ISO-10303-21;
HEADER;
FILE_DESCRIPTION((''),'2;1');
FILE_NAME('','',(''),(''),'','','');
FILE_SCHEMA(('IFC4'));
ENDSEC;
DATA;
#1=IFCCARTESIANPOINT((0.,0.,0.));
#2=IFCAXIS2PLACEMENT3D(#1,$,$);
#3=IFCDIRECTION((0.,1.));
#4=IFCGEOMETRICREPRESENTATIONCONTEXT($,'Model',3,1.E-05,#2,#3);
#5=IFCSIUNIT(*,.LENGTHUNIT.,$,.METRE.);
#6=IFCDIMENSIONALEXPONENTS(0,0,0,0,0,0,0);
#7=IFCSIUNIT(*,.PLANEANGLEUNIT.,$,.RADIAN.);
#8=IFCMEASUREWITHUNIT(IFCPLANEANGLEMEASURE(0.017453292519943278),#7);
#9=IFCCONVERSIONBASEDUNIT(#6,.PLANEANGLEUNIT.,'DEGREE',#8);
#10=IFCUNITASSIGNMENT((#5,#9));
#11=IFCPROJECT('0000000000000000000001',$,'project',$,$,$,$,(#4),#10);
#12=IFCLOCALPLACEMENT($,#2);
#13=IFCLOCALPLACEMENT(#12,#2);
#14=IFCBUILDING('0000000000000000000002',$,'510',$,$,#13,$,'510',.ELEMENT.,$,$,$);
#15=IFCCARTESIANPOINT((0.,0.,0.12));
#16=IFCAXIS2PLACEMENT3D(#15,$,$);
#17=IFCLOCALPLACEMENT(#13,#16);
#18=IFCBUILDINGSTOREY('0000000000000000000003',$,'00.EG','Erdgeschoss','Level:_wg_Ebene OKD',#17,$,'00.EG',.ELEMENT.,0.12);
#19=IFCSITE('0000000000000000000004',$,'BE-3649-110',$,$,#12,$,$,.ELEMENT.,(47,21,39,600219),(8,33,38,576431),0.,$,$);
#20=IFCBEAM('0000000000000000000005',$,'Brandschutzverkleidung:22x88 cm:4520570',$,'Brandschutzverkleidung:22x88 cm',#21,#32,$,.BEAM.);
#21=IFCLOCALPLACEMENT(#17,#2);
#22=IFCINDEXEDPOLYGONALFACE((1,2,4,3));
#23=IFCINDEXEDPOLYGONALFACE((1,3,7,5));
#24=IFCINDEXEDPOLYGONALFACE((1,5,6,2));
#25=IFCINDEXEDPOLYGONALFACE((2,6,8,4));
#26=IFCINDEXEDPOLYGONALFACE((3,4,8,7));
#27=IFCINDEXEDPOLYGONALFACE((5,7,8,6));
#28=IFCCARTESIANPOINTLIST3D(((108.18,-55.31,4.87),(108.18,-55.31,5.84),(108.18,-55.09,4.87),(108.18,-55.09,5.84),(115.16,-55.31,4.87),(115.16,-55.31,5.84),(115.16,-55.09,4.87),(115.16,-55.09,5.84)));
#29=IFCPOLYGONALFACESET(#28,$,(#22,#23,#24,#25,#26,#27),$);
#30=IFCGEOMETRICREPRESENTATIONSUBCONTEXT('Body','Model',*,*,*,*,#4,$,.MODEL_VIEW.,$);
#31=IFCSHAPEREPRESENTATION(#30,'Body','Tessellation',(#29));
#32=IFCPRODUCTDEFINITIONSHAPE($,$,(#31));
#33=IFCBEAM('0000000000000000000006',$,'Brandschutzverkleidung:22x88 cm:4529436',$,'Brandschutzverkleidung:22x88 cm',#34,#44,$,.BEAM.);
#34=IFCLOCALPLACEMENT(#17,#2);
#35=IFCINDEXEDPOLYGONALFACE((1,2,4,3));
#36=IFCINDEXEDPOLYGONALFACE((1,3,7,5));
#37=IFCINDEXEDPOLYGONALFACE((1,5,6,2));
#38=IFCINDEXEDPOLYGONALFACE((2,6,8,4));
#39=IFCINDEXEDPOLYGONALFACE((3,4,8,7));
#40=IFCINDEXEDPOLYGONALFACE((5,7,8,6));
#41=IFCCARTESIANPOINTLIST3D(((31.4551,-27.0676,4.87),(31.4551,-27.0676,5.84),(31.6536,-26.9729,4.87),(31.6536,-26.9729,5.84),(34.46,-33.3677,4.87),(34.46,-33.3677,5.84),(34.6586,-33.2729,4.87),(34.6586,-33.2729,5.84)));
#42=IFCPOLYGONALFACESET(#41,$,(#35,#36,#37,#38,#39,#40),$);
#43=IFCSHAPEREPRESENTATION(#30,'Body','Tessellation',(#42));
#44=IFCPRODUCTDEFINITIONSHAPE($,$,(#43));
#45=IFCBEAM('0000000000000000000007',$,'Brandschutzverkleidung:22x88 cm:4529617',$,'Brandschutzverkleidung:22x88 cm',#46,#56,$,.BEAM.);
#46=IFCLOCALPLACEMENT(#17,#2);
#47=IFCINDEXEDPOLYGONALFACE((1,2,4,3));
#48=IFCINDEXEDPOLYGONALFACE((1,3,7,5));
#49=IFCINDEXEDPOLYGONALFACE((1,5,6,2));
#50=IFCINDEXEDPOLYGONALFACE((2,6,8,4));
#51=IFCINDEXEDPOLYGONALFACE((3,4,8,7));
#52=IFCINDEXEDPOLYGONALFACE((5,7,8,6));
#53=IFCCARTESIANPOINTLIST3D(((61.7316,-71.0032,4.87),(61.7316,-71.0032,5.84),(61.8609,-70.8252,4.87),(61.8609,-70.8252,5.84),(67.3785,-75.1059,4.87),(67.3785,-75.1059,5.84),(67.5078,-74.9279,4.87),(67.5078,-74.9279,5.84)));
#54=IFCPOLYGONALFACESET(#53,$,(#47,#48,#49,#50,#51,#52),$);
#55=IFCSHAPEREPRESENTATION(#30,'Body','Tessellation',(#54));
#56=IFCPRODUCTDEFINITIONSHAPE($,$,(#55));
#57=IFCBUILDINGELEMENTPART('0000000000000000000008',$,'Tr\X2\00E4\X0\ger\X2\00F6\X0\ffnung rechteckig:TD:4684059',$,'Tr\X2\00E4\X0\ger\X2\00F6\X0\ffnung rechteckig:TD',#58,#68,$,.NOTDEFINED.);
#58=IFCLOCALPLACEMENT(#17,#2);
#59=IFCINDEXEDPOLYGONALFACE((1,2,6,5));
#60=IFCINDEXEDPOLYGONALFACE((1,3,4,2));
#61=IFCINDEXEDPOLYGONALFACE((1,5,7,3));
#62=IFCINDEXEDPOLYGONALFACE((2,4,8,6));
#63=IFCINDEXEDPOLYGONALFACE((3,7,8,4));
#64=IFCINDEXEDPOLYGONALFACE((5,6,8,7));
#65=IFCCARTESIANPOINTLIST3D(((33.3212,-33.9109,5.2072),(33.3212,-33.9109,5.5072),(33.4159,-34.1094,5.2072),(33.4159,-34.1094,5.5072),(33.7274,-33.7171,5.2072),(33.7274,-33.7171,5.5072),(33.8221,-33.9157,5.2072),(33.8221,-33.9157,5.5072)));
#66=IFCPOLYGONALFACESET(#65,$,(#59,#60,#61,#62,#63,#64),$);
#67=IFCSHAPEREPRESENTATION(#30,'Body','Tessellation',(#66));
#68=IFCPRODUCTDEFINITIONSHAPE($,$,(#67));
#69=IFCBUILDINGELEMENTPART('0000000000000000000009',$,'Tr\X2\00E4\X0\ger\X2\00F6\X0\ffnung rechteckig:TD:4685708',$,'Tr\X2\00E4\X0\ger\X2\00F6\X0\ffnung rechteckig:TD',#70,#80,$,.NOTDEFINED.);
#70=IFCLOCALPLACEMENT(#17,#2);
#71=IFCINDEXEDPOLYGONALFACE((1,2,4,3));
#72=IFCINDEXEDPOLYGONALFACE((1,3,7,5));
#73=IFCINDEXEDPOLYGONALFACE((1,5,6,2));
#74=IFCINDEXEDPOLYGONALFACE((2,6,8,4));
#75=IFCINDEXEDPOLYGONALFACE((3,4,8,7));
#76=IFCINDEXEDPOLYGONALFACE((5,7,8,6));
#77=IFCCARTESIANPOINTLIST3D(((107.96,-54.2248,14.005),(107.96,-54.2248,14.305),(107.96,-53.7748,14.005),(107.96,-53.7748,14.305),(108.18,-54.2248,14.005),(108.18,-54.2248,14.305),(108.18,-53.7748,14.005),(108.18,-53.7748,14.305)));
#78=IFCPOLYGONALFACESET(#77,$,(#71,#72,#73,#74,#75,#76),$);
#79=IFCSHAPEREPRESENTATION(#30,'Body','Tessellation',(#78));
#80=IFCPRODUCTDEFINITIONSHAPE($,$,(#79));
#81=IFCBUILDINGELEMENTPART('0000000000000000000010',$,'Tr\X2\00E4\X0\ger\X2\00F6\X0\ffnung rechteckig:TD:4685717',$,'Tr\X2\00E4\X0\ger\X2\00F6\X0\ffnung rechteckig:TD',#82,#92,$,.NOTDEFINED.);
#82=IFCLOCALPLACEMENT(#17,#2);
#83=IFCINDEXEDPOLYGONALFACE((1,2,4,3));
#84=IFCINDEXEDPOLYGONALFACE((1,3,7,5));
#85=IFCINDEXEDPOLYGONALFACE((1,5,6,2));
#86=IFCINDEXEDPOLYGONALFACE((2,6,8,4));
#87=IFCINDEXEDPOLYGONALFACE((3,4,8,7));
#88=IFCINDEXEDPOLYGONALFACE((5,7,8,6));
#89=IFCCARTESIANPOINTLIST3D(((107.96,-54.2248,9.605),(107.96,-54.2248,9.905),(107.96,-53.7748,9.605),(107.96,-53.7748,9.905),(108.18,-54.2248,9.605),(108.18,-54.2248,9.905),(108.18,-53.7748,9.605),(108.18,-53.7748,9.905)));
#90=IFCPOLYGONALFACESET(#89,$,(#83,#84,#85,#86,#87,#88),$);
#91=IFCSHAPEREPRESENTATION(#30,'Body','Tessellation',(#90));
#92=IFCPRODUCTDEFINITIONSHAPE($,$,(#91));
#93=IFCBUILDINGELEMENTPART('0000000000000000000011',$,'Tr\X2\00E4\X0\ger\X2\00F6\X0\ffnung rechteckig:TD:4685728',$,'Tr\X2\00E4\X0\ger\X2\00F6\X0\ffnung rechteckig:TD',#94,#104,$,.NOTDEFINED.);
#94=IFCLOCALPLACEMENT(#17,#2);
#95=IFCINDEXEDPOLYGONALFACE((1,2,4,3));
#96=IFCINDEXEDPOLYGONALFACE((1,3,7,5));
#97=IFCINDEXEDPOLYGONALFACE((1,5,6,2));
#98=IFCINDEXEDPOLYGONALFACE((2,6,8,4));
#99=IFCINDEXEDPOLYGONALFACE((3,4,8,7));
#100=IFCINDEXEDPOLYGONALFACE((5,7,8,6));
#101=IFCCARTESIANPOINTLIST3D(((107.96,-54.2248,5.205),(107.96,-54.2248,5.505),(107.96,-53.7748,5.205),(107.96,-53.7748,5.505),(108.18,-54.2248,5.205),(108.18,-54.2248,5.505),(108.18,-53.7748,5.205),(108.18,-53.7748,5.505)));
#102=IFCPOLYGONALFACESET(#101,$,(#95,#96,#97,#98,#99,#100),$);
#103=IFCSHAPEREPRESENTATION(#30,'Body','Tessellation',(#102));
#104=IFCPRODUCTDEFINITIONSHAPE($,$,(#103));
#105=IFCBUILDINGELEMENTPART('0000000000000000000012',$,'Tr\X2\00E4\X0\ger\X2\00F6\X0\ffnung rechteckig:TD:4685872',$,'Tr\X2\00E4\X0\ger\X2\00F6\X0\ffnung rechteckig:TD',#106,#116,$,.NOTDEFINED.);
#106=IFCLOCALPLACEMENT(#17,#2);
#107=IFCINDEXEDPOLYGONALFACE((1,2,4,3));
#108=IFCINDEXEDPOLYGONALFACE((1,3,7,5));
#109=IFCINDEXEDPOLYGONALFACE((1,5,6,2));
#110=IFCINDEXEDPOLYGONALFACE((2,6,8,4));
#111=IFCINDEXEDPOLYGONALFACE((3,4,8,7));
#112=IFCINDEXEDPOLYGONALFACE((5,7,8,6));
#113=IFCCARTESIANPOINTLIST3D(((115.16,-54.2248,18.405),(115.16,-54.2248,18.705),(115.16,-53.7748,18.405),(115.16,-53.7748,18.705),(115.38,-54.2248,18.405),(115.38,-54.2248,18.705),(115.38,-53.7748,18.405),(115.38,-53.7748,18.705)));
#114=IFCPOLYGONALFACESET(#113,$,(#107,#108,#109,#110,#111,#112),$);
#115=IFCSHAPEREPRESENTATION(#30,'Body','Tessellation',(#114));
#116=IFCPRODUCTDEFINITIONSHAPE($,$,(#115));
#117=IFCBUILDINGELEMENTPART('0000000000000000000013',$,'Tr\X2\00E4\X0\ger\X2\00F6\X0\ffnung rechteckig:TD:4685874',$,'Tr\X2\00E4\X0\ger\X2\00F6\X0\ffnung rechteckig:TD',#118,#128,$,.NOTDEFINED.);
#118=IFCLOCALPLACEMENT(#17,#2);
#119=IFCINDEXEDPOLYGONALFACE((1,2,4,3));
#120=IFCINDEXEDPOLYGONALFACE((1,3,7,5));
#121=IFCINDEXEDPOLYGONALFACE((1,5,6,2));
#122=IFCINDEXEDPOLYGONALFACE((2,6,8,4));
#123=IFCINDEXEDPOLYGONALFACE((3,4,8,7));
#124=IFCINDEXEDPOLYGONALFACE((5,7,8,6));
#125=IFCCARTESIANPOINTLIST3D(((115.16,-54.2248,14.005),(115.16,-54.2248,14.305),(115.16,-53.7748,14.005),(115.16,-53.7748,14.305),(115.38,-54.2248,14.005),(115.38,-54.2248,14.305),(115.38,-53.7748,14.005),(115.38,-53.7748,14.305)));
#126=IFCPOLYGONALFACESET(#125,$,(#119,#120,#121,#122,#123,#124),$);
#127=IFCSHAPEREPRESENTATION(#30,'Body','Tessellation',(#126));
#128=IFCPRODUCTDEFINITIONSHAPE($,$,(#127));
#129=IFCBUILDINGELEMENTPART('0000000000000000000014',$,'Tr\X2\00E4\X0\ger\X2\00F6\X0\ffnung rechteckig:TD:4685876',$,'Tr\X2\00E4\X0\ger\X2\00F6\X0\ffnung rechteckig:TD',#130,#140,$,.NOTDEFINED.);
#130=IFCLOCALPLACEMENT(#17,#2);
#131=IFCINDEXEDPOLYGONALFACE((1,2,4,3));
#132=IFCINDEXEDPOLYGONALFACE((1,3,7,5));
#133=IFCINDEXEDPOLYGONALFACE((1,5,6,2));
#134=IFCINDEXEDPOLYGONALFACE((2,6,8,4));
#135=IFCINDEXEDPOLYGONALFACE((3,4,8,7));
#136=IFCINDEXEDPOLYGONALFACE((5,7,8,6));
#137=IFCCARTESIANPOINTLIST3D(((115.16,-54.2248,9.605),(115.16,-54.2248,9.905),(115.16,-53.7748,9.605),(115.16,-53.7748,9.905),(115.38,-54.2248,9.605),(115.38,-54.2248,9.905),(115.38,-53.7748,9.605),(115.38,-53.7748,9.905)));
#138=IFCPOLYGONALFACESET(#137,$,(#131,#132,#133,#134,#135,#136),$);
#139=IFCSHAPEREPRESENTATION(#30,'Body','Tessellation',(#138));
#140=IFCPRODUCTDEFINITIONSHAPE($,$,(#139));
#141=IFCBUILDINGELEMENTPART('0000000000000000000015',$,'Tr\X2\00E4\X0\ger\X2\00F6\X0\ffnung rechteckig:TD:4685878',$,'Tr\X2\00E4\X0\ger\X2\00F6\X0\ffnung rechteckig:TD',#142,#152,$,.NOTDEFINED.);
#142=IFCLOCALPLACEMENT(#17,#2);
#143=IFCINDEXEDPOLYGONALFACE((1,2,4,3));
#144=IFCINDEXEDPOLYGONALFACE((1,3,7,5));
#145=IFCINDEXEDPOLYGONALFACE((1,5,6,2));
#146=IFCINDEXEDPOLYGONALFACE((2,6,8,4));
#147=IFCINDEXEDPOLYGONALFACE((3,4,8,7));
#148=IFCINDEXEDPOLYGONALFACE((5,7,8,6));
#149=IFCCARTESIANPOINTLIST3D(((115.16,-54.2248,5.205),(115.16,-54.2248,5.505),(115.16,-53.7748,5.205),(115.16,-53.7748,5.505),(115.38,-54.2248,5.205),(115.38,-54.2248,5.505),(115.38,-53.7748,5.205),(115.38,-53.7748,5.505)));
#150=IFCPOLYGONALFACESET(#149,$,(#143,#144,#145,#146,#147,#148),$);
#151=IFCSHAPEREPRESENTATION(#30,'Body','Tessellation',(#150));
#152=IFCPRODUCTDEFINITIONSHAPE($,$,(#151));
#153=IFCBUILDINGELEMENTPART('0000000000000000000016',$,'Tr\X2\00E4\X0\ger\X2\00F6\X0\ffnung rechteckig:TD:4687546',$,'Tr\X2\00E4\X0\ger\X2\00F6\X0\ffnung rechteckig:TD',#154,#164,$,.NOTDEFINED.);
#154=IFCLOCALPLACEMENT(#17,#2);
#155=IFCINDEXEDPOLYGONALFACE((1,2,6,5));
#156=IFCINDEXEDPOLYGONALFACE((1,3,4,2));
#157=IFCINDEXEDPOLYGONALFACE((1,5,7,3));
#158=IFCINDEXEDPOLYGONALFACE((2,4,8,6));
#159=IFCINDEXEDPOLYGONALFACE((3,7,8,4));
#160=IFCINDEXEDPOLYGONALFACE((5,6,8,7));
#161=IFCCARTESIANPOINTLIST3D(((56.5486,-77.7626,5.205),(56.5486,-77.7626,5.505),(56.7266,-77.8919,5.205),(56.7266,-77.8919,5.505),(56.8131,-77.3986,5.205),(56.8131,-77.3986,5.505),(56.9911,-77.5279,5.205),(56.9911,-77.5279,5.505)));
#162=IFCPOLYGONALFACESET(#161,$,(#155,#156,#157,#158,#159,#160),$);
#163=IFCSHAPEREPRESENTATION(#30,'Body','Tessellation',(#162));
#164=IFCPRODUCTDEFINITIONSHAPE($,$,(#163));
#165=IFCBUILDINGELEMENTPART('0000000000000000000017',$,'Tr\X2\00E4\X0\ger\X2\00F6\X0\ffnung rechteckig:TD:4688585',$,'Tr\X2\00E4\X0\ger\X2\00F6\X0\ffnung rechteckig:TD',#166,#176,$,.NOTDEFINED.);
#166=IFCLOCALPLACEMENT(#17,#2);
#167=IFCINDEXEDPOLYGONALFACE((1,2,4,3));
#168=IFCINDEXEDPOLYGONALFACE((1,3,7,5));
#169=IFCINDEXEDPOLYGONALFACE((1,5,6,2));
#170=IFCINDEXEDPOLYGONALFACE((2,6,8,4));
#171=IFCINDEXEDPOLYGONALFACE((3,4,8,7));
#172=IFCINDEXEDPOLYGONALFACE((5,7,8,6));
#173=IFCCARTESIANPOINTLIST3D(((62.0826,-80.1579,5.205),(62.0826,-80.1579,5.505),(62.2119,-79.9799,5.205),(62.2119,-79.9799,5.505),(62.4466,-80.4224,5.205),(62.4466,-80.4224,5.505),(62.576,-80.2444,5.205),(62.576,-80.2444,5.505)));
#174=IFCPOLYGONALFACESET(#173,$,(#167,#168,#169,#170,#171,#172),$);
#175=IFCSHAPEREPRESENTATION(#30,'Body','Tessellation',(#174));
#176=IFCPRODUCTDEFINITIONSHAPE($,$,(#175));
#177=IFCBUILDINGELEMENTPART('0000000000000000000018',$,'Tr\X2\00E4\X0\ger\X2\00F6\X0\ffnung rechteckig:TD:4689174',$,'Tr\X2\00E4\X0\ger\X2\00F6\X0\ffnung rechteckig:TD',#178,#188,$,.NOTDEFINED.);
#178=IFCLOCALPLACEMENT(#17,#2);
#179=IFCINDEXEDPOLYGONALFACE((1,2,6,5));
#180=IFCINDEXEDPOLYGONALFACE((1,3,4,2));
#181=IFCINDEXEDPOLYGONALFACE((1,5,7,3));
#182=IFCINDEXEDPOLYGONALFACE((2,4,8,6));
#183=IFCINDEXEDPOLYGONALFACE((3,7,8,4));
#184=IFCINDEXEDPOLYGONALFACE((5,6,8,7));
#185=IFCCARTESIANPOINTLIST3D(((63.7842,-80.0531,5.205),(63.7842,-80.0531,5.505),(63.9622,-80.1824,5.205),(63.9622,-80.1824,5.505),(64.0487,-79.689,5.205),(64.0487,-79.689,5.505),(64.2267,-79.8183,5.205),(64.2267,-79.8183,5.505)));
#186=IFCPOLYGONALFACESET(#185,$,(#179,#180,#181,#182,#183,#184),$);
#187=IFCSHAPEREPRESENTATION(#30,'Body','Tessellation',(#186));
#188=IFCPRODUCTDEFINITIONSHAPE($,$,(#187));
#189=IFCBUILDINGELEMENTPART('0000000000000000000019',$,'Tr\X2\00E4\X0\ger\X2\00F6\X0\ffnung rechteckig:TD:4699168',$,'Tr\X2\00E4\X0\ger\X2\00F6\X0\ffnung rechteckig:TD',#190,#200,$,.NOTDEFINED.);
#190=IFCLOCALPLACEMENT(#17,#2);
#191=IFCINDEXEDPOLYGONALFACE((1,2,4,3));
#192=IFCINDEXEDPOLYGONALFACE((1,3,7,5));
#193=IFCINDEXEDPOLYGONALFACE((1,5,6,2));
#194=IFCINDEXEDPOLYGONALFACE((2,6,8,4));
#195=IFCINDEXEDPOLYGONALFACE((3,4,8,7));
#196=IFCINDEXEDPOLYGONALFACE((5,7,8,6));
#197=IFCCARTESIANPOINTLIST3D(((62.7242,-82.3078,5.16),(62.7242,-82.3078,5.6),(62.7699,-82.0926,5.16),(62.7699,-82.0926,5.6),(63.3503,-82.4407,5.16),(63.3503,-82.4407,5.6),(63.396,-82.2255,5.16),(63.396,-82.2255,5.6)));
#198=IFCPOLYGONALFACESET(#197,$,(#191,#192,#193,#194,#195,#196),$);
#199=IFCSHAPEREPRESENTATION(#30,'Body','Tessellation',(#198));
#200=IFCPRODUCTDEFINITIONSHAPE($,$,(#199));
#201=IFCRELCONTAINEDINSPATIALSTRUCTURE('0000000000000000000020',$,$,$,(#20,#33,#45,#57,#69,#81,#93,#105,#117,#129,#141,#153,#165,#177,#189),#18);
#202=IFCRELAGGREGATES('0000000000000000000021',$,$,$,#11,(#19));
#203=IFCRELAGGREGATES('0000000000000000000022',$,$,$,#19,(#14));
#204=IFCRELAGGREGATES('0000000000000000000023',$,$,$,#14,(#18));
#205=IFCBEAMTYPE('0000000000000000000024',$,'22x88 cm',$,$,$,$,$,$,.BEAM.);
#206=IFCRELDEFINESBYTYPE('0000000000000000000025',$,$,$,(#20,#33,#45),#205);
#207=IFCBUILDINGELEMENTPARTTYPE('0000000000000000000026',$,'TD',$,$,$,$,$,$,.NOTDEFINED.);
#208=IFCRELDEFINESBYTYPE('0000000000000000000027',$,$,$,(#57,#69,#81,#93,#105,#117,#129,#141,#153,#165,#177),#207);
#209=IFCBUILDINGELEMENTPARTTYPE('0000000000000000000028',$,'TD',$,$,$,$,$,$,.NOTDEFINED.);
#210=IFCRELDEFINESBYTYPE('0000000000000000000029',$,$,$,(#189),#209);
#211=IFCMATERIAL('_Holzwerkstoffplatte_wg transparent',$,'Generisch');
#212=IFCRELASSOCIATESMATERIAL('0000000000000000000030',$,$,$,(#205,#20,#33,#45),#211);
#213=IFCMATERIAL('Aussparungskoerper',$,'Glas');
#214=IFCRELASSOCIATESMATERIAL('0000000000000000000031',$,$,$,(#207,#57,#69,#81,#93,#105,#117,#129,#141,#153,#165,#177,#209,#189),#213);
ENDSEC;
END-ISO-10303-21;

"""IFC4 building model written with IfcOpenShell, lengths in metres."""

from ifc_helpers import new_model, entity, si_unit, converted_unit, direction, frame, origin, place, context, subcontext, project, spatial, indexed_curve, outline, extrude, source, transform, mapped, material, type_object, type_shapes, element, save


model = new_model("IFC4")

# Units and contexts
model_context = context("Model", 3, precision=1e-05, world=origin(), true_north=direction((0.0, 1.0)))
body_context = subcontext(model_context, "Body", "Model", "MODEL_VIEW")
ifc_project = project(units=[si_unit("LENGTHUNIT", "METRE"), converted_unit("PLANEANGLEUNIT", "DEGREE", entity("IfcPlaneAngleMeasure", 0.017453292519943278), si_unit("PLANEANGLEUNIT", "RADIAN"), dimensions=[0, 0, 0, 0, 0, 0, 0])], contexts=[model_context])

# Site, building, storey
site_placement = place(None, origin())
site = spatial("IfcSite", under=ifc_project, at=site_placement, Name="BE-3649-110", CompositionType="ELEMENT", RefLatitude=(47, 21, 39, 600219), RefLongitude=(8, 33, 38, 576431), RefElevation=0.0)
building_placement = place(site_placement, origin())
building = spatial("IfcBuilding", under=site, at=building_placement, Name="510", LongName="510", CompositionType="ELEMENT")
storey_placement = place(building_placement, frame((0.0, 0.0, 0.12)))
storey = spatial("IfcBuildingStorey", under=building, at=storey_placement, Name="00.EG", Description="Erdgeschoss", ObjectType="Level:_wg_Ebene OKD", LongName="00.EG", CompositionType="ELEMENT", Elevation=0.12)

# Shared definitions
ifc_material_1 = material(Name="_Holzwerkstoffplatte_wg transparent", Category="Generisch")

# Beams
beam_type_1 = type_object("IfcBeamType", Name="22x88 cm", PredefinedType="BEAM", material=ifc_material_1)
shared_shape_1 = source(origin(), body_context, "Body", "SweptSolid", [
    extrude(outline(indexed_curve([(-3.49, -0.11), (3.49, -0.11), (3.49, 0.11), (-3.49, 0.11), (-3.49, -0.11)], self_intersect=False)), frame((0.0, 0.0, -0.485)), (0.0, 0.0, 1.0), 0.97),
])
type_shapes(beam_type_1, [shared_shape_1])
beam_1_placement = place(storey_placement, frame((111.67, -55.2, 5.355)))
element("IfcBeam", 1, at=beam_1_placement, inside=storey, type_object=beam_type_1, material=ifc_material_1, Name="Brandschutzverkleidung:22x88 cm:4520570", ObjectType="Brandschutzverkleidung:22x88 cm", PredefinedType="BEAM", context=body_context, shape_type="MappedRepresentation", body=[
    mapped(shared_shape_1, transform((0.0, 0.0, 0.0), scale=1.0)),
])
for number, where, z_axis, x_axis, name in (
    (2, (33.0568, -30.1703, 5.355), (0.0, 0.0, 1.0), (0.430511, -0.902585, 0.0), "Brandschutzverkleidung:22x88 cm:4529436"),
    (3, (64.6197, -72.9655, 5.355), (0.0, 0.0, 1.0), (0.809017, -0.587785, 0.0), "Brandschutzverkleidung:22x88 cm:4529617"),
):
    element("IfcBeam", number, at=place(storey_placement, frame(where, z_axis=z_axis, x_axis=x_axis)), inside=storey, type_object=beam_type_1, material=ifc_material_1, Name=name, ObjectType="Brandschutzverkleidung:22x88 cm", PredefinedType="BEAM", context=body_context, shape_type="MappedRepresentation", body=[
        mapped(shared_shape_1, transform((0.0, 0.0, 0.0), scale=1.0)),
    ])

# Building element parts
ifc_material_2 = material(Name="Aussparungskoerper", Category="Glas")
building_element_part_type_1 = type_object("IfcBuildingElementPartType", Name="TD", PredefinedType="NOTDEFINED", material=ifc_material_2)
shared_shape_2 = source(origin(), body_context, "Body", "SweptSolid", [
    extrude(outline(indexed_curve([(-0.225, -0.15), (0.225, -0.15), (0.225, 0.15), (-0.225, 0.15), (-0.225, -0.15)], self_intersect=False)), frame((0.0, 0.0, -0.22), z_axis=(0.0, 0.0, 1.0), x_axis=(-1.0, 0.0, 0.0)), (0.0, 0.0, 1.0), 0.22),
])
type_shapes(building_element_part_type_1, [shared_shape_2])
for number, where, z_axis, x_axis, name in (
    (4, (33.619, -34.0126, 5.3572), (0.430511, -0.902585, 0.0), (-0.902585, -0.430511, 0.0), "Trägeröffnung rechteckig:TD:4684059"),
    (5, (107.96, -53.9998, 14.155), (-1.0, 0.0, 0.0), (0.0, -1.0, 0.0), "Trägeröffnung rechteckig:TD:4685708"),
    (6, (107.96, -53.9998, 9.755), (-1.0, 0.0, 0.0), (0.0, -1.0, 0.0), "Trägeröffnung rechteckig:TD:4685717"),
    (7, (107.96, -53.9998, 5.355), (-1.0, 0.0, 0.0), (0.0, -1.0, 0.0), "Trägeröffnung rechteckig:TD:4685728"),
    (8, (115.16, -53.9998, 18.555), (-1.0, 0.0, 0.0), (0.0, -1.0, 0.0), "Trägeröffnung rechteckig:TD:4685872"),
    (9, (115.16, -53.9998, 14.155), (-1.0, 0.0, 0.0), (0.0, -1.0, 0.0), "Trägeröffnung rechteckig:TD:4685874"),
    (10, (115.16, -53.9998, 9.755), (-1.0, 0.0, 0.0), (0.0, -1.0, 0.0), "Trägeröffnung rechteckig:TD:4685876"),
    (11, (115.16, -53.9998, 5.355), (-1.0, 0.0, 0.0), (0.0, -1.0, 0.0), "Trägeröffnung rechteckig:TD:4685878"),
    (12, (56.8588, -77.7099, 5.355), (0.809017, -0.587785, 0.0), (-0.587785, -0.809017, 0.0), "Trägeröffnung rechteckig:TD:4687546"),
    (13, (62.2646, -80.2901, 5.355), (-0.587785, -0.809017, 0.0), (0.809017, -0.587785, 0.0), "Trägeröffnung rechteckig:TD:4688585"),
    (14, (64.0944, -80.0003, 5.355), (0.809017, -0.587785, 0.0), (-0.587785, -0.809017, 0.0), "Trägeröffnung rechteckig:TD:4689174"),
):
    element("IfcBuildingElementPart", number, at=place(storey_placement, frame(where, z_axis=z_axis, x_axis=x_axis)), inside=storey, type_object=building_element_part_type_1, material=ifc_material_2, Name=name, ObjectType="Trägeröffnung rechteckig:TD", PredefinedType="NOTDEFINED", context=body_context, shape_type="MappedRepresentation", body=[
        mapped(shared_shape_2, transform((0.0, 0.0, 0.0), scale=1.0)),
    ])
building_element_part_type_2 = type_object("IfcBuildingElementPartType", Name="TD", PredefinedType="NOTDEFINED", material=ifc_material_2)
shared_shape_3 = source(origin(), body_context, "Body", "SweptSolid", [
    extrude(outline(indexed_curve([(-0.22, -0.32), (0.22, -0.32), (0.22, 0.32), (-0.22, 0.32), (-0.22, -0.32)], self_intersect=False)), frame((0.0, 0.0, -0.22), z_axis=(0.0, 0.0, 1.0), x_axis=(0.0, 1.0, 0.0)), (0.0, 0.0, 1.0), 0.22),
])
type_shapes(building_element_part_type_2, [shared_shape_3])
building_element_part_placement = place(storey_placement, frame((63.0373, -82.3742, 5.38), z_axis=(-0.207566, -0.978221, 0.0), x_axis=(0.978221, -0.207566, 0.0)))
element("IfcBuildingElementPart", 15, at=building_element_part_placement, inside=storey, type_object=building_element_part_type_2, material=ifc_material_2, Name="Trägeröffnung rechteckig:TD:4699168", ObjectType="Trägeröffnung rechteckig:TD", PredefinedType="NOTDEFINED", context=body_context, shape_type="MappedRepresentation", body=[
    mapped(shared_shape_3, transform((0.0, 0.0, 0.0), scale=1.0)),
])

save(model, "model.ifc")
